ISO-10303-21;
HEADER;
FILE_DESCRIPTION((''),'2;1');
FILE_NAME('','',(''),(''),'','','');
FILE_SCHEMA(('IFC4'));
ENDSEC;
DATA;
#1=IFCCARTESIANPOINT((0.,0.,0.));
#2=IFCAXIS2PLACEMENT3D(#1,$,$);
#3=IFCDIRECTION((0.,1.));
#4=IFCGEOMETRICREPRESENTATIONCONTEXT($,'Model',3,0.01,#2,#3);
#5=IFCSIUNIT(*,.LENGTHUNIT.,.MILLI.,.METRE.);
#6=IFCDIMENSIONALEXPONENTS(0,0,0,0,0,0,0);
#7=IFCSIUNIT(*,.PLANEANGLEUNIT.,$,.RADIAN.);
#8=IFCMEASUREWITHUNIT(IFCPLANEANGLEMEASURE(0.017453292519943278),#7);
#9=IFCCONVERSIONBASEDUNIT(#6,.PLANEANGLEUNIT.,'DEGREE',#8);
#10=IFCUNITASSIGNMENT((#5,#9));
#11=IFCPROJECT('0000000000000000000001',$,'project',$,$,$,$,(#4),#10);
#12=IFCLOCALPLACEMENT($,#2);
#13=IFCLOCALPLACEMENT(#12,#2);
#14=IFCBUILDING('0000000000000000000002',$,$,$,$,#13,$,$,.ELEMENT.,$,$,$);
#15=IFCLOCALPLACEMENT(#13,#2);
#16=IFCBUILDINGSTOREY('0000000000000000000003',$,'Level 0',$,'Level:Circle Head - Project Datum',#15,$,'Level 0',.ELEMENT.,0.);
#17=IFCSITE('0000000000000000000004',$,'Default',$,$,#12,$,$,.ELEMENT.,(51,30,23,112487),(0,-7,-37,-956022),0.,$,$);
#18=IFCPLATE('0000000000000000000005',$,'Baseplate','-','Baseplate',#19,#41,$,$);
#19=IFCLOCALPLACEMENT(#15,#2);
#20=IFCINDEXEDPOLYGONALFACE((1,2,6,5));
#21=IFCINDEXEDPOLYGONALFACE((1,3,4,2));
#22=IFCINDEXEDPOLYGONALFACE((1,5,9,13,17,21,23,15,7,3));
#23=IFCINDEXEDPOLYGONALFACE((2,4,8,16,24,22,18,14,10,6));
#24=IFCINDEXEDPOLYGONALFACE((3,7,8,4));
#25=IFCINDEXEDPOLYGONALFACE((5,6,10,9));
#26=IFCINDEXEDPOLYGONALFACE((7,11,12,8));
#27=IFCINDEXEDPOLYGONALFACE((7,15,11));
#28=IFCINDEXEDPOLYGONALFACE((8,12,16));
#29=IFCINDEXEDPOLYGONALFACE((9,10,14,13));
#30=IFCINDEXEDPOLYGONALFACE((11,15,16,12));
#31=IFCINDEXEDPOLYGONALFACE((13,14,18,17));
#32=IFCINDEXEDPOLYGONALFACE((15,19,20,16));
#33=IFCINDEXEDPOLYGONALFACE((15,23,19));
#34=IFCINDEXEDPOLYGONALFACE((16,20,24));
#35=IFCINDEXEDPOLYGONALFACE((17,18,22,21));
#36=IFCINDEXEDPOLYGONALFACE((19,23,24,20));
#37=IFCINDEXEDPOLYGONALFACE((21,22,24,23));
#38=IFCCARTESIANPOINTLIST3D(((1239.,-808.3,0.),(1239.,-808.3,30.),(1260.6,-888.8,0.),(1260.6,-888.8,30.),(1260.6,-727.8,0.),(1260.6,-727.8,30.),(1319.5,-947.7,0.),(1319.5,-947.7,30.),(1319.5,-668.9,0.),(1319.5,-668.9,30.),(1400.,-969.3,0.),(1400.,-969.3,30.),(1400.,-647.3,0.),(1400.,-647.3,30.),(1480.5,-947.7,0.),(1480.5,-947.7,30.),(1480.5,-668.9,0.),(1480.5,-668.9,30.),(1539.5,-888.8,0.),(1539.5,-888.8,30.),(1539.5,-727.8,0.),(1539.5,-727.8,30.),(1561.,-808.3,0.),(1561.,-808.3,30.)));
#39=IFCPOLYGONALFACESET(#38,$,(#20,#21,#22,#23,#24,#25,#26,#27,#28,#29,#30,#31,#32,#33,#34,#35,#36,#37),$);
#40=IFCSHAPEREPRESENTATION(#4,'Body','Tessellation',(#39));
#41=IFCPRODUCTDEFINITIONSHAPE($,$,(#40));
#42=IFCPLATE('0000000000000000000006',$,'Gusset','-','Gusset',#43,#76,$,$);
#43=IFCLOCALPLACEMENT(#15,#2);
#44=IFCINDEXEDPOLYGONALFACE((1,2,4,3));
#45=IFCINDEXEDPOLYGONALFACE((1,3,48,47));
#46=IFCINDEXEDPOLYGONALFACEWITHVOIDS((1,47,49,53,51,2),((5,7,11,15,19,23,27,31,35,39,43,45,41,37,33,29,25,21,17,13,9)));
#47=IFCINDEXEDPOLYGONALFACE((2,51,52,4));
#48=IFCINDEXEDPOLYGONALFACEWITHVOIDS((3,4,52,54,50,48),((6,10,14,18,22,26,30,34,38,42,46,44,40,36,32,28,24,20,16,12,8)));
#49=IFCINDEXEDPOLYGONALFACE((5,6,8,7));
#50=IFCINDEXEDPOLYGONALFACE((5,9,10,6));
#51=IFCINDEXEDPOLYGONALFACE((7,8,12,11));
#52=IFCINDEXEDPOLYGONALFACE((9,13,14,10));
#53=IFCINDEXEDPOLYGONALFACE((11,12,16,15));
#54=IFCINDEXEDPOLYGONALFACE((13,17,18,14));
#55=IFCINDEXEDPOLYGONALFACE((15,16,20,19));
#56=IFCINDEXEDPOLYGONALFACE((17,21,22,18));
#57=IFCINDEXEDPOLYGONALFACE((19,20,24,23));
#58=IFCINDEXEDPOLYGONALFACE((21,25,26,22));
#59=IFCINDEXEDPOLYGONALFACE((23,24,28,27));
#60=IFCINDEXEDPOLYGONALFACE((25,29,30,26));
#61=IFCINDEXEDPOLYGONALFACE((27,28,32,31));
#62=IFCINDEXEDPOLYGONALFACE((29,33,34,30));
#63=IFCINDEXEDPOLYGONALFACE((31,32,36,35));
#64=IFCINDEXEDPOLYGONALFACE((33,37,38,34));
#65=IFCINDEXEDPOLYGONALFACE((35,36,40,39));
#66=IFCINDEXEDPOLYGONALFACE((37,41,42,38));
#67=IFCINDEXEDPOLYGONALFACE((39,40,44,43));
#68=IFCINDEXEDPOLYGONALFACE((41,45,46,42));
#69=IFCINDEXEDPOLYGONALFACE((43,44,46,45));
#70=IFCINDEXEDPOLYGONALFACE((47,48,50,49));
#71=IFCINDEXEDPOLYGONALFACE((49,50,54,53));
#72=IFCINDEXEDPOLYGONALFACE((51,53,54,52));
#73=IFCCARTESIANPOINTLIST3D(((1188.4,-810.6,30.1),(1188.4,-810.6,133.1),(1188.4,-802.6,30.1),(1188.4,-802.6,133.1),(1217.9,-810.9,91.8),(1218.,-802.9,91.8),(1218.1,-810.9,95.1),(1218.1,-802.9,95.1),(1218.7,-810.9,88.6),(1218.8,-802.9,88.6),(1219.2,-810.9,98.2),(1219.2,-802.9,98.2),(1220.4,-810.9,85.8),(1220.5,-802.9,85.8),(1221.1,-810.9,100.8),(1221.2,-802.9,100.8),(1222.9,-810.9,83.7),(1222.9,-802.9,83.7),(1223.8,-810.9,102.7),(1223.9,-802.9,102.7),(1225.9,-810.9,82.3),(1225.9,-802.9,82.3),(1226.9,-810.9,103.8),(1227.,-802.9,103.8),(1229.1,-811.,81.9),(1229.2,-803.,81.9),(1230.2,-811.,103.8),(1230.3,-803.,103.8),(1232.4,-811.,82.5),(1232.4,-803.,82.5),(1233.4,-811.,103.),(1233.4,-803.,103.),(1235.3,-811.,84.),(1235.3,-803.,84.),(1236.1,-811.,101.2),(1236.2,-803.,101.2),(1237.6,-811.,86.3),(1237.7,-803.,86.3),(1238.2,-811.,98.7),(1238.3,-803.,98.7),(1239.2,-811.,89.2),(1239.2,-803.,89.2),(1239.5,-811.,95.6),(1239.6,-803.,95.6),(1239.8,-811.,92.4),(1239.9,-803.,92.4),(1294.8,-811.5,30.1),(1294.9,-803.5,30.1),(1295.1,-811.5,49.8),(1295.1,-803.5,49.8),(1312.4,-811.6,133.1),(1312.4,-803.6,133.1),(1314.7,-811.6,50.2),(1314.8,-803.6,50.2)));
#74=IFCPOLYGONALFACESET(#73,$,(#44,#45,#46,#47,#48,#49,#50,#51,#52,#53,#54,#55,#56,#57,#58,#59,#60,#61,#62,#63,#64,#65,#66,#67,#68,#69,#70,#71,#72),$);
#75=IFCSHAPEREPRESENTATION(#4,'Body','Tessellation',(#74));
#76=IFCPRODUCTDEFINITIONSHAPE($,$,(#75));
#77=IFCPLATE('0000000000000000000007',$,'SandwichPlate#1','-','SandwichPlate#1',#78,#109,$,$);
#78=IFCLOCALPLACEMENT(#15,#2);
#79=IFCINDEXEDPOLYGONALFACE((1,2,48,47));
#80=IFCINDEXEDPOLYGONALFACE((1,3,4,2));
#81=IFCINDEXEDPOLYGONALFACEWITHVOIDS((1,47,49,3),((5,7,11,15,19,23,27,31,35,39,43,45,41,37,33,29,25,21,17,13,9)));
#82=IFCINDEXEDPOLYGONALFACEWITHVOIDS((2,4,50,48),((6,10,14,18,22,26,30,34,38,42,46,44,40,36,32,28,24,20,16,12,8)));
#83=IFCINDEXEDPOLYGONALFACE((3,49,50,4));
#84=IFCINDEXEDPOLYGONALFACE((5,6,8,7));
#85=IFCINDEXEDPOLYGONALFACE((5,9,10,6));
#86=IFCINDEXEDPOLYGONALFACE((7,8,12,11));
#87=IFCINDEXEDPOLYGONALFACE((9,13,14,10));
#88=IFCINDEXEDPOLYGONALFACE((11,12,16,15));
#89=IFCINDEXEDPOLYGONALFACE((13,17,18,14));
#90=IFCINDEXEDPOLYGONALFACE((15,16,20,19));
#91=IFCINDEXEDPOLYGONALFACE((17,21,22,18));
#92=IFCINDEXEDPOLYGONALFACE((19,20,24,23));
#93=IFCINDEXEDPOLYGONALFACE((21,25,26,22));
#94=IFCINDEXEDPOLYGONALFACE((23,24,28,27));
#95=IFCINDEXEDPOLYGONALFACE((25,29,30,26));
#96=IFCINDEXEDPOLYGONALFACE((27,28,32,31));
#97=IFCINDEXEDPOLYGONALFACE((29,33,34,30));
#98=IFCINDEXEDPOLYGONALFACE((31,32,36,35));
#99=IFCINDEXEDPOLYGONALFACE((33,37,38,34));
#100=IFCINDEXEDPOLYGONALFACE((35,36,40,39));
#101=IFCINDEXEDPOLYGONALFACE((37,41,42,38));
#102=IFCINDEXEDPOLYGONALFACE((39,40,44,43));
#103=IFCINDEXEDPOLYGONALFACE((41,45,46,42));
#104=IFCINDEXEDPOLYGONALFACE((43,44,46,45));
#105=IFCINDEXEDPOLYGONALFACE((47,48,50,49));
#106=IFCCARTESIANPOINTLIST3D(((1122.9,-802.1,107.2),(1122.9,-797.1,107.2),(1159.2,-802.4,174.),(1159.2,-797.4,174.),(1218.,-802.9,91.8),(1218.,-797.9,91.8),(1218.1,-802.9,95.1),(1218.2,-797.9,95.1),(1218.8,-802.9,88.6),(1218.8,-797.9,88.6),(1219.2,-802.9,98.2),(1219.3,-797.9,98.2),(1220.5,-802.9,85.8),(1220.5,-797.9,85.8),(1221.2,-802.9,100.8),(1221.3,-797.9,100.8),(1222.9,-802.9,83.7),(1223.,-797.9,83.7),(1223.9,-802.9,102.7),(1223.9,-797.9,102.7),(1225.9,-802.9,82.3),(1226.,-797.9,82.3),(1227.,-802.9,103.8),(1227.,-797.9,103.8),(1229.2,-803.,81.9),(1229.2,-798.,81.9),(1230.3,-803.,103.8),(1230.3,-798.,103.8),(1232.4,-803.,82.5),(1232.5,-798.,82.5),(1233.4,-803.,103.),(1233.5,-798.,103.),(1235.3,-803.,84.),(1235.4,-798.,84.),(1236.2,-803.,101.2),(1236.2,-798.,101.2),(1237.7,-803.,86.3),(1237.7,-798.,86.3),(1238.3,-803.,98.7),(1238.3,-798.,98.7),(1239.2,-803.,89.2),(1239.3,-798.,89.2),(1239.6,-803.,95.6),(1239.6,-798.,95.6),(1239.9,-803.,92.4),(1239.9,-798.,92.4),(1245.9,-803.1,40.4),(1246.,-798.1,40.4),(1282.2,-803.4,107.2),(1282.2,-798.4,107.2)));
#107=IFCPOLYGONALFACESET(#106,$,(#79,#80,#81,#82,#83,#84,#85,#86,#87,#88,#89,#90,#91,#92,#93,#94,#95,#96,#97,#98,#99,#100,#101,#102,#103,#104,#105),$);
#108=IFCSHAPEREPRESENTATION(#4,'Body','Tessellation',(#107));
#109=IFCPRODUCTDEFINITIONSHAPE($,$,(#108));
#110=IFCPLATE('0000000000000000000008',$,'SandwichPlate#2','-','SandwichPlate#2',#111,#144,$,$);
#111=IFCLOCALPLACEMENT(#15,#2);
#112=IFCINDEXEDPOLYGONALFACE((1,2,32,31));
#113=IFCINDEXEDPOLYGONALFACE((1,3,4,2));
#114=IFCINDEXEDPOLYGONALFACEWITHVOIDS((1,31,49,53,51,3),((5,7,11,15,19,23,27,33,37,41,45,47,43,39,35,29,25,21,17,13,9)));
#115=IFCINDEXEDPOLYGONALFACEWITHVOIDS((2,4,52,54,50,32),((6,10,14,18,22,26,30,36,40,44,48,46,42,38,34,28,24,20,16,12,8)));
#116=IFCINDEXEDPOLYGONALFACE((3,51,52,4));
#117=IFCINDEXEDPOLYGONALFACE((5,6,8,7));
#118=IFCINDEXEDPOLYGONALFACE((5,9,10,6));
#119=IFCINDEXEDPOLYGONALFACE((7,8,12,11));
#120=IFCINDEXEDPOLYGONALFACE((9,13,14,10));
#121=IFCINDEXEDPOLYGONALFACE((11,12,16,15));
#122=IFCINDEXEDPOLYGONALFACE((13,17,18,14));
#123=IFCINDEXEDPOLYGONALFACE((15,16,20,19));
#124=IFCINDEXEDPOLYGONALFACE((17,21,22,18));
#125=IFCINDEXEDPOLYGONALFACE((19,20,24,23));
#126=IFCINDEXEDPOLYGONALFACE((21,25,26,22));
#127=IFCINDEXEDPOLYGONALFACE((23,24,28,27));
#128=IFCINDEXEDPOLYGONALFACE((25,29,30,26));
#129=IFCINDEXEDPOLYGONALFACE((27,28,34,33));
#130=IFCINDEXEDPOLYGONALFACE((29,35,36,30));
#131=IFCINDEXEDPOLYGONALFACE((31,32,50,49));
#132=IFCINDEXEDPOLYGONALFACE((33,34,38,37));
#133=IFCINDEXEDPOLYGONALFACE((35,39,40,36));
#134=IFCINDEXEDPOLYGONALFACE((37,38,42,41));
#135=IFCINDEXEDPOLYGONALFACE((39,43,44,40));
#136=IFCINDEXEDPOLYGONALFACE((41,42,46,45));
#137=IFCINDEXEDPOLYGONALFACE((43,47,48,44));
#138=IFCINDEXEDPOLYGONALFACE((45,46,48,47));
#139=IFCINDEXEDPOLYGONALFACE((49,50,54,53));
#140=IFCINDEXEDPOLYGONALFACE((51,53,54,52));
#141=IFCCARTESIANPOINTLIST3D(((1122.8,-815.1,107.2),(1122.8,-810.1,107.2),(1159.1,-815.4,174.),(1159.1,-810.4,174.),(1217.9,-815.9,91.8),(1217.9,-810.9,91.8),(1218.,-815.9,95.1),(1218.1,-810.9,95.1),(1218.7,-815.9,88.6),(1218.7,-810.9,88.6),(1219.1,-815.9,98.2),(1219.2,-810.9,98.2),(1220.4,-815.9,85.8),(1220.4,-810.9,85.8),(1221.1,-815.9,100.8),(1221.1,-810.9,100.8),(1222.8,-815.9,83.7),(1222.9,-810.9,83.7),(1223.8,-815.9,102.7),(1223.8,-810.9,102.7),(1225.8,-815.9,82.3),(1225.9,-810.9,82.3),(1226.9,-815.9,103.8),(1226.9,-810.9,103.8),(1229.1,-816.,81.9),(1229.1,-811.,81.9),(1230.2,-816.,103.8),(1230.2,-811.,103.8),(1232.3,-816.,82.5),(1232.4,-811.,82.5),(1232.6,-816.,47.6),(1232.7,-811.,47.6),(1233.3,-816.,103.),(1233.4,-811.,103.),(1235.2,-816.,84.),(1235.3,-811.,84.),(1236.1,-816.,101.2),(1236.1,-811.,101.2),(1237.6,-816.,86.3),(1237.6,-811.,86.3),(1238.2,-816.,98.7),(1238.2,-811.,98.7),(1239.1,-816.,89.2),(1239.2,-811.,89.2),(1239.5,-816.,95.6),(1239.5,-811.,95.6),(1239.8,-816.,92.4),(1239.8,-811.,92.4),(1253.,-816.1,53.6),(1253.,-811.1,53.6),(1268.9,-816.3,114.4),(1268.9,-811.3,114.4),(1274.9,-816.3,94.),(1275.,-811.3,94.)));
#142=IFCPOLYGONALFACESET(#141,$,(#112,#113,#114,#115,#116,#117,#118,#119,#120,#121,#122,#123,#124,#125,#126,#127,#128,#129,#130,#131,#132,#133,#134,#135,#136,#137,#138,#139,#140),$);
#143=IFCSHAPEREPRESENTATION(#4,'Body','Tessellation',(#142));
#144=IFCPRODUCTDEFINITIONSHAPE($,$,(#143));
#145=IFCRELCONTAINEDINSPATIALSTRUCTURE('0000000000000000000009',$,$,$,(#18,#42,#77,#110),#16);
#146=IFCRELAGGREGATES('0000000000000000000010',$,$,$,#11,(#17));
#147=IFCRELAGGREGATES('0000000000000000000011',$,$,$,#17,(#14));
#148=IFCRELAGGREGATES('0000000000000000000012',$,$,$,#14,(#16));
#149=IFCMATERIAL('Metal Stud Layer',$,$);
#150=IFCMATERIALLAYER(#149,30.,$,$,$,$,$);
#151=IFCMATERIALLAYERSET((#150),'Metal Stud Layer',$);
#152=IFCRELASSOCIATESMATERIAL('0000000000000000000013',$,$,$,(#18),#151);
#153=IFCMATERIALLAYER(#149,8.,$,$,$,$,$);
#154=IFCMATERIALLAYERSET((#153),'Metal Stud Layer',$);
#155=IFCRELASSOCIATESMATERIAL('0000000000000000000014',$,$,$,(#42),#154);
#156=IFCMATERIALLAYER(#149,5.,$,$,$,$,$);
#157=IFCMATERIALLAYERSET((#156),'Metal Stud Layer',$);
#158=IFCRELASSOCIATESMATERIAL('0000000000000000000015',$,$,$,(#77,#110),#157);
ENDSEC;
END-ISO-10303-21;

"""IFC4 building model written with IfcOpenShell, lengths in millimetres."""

from ifc_helpers import new_model, entity, si_unit, converted_unit, point, direction, frame, frame_2d, origin, origin_with_axes, origin_2d_with_axis, place, context, project, spatial, polyline, circle_curve, line_curve, trimmed, segment, composite_curve, circle, outline, extrude, material, layer, layer_set, element, save


model = new_model("IFC4")

# Units and contexts
model_context = context("Model", 3, precision=0.01, world=origin(), true_north=direction((0.0, 1.0)))
ifc_project = project(units=[si_unit("LENGTHUNIT", "METRE", prefix="MILLI"), converted_unit("PLANEANGLEUNIT", "DEGREE", entity("IfcPlaneAngleMeasure", 0.017453292519943278), si_unit("PLANEANGLEUNIT", "RADIAN"), dimensions=[0, 0, 0, 0, 0, 0, 0])], contexts=[model_context])

# Site, building, storey
site_placement = place(None, origin())
site = spatial("IfcSite", under=ifc_project, at=site_placement, Name="Default", CompositionType="ELEMENT", RefLatitude=(51, 30, 23, 112487), RefLongitude=(0, -7, -37, -956022), RefElevation=0.0)
building_placement = place(site_placement, origin())
building = spatial("IfcBuilding", under=site, at=building_placement, CompositionType="ELEMENT")
storey_placement = place(building_placement, origin())
storey = spatial("IfcBuildingStorey", under=building, at=storey_placement, Name="Level 0", ObjectType="Level:Circle Head - Project Datum", LongName="Level 0", CompositionType="ELEMENT", Elevation=0.0)

# Plates, openings
ifc_material_1 = material(Name="Metal Stud Layer")
ifc_layer_1 = layer(ifc_material_1, 30.0)
ifc_layer_set_1 = layer_set([ifc_layer_1], Name="Metal Stud Layer")
plate_1_placement = place(storey_placement, frame((1480.5, -668.9, 30.0), z_axis=(0.0, 0.0, -1.0), x_axis=(0.866025, -0.5, 0.0)))
plate_1 = element("IfcPlate", 1, at=plate_1_placement, inside=storey, material=ifc_layer_set_1, Name="Baseplate", Description="-", ObjectType="Baseplate", context=model_context, shape_type="SweptSolid", body=[
    extrude(outline(polyline([(161.0, 0.0), (161.0, 322.0), (-161.0, 322.0), (-161.0, 0.0), (161.0, 0.0)])), origin_with_axes(), (0.0, 0.0, 1.0), 30.0),
])
opening_1_placement = place(plate_1_placement, frame((0.0, 0.0, 0.0), z_axis=(0.0, 0.0, 1.0), x_axis=(1.0, 0.0, 0.0)))
element("IfcOpeningElement", 2, at=opening_1_placement, cuts=plate_1, ObjectType="Opening", context=model_context, shape_type="SweptSolid", body=[
    extrude(outline(composite_curve([segment(trimmed(line_curve((161.0, 0.0), (0.0, 1.0), 161.0), [point((161.0, 0.0))], [point((161.0, 161.0))], True, "CARTESIAN"), True, "CONTINUOUS"), segment(trimmed(circle_curve(frame_2d((0.0, 161.0), x_axis=(-1.0, 0.0)), 161.0), [point((161.0, 161.0))], [point((0.0, 0.0))], False, "CARTESIAN"), True, "CONTINUOUS"), segment(trimmed(line_curve((0.0, 0.0), (1.0, 0.0), 161.0), [point((0.0, 0.0))], [point((161.0, 0.0))], True, "CARTESIAN"), True, "CONTINUOUS")], self_intersect="UNKNOWN")), origin(), (0.0, 0.0, 1.0), 30.0),
])
opening_2_placement = place(plate_1_placement, frame((0.0, 0.0, 0.0), z_axis=(0.0, 0.0, 1.0), x_axis=(1.0, 0.0, 0.0)))
element("IfcOpeningElement", 3, at=opening_2_placement, cuts=plate_1, ObjectType="Opening", context=model_context, shape_type="SweptSolid", body=[
    extrude(outline(composite_curve([segment(trimmed(line_curve((161.0, 322.0), (-1.0, 0.0), 161.0), [point((161.0, 322.0))], [point((0.0, 322.0))], True, "CARTESIAN"), True, "CONTINUOUS"), segment(trimmed(circle_curve(frame_2d((0.0, 161.0), x_axis=(-1.0, 0.0)), 161.0), [point((0.0, 322.0))], [point((161.0, 161.0))], False, "CARTESIAN"), True, "CONTINUOUS"), segment(trimmed(line_curve((161.0, 161.0), (0.0, 1.0), 161.0), [point((161.0, 161.0))], [point((161.0, 322.0))], True, "CARTESIAN"), True, "CONTINUOUS")], self_intersect="UNKNOWN")), origin(), (0.0, 0.0, 1.0), 30.0),
])
opening_3_placement = place(plate_1_placement, frame((0.0, 0.0, 0.0), z_axis=(0.0, 0.0, 1.0), x_axis=(1.0, 0.0, 0.0)))
element("IfcOpeningElement", 4, at=opening_3_placement, cuts=plate_1, ObjectType="Opening", context=model_context, shape_type="SweptSolid", body=[
    extrude(outline(composite_curve([segment(trimmed(line_curve((-161.0, 322.0), (0.0, -1.0), 161.0), [point((-161.0, 322.0))], [point((-161.0, 161.0))], True, "CARTESIAN"), True, "CONTINUOUS"), segment(trimmed(circle_curve(frame_2d((0.0, 161.0), x_axis=(-1.0, 0.0)), 161.0), [point((-161.0, 161.0))], [point((0.0, 322.0))], False, "CARTESIAN"), True, "CONTINUOUS"), segment(trimmed(line_curve((0.0, 322.0), (-1.0, 0.0), 161.0), [point((0.0, 322.0))], [point((-161.0, 322.0))], True, "CARTESIAN"), True, "CONTINUOUS")], self_intersect="UNKNOWN")), origin(), (0.0, 0.0, 1.0), 30.0),
])
opening_4_placement = place(plate_1_placement, frame((0.0, 0.0, 0.0), z_axis=(0.0, 0.0, 1.0), x_axis=(1.0, 0.0, 0.0)))
element("IfcOpeningElement", 5, at=opening_4_placement, cuts=plate_1, ObjectType="Opening", context=model_context, shape_type="SweptSolid", body=[
    extrude(outline(composite_curve([segment(trimmed(line_curve((-161.0, 0.0), (1.0, 0.0), 161.0), [point((-161.0, 0.0))], [point((0.0, 0.0))], True, "CARTESIAN"), True, "CONTINUOUS"), segment(trimmed(circle_curve(frame_2d((0.0, 161.0), x_axis=(-1.0, 0.0)), 161.0), [point((0.0, 0.0))], [point((-161.0, 161.0))], False, "CARTESIAN"), True, "CONTINUOUS"), segment(trimmed(line_curve((-161.0, 161.0), (0.0, -1.0), 161.0), [point((-161.0, 161.0))], [point((-161.0, 0.0))], True, "CARTESIAN"), True, "CONTINUOUS")], self_intersect="UNKNOWN")), origin(), (0.0, 0.0, 1.0), 30.0),
])
ifc_layer_2 = layer(ifc_material_1, 8.0)
ifc_layer_set_2 = layer_set([ifc_layer_2], Name="Metal Stud Layer")
plate_2_placement = place(storey_placement, frame((1309.2, -803.6, 143.6), z_axis=(-0.007837, -0.999969, 0.0), x_axis=(-0.999419, 0.007833, -0.033166)))
plate_2 = element("IfcPlate", 6, at=plate_2_placement, inside=storey, material=ifc_layer_set_2, Name="Gusset", Description="-", ObjectType="Gusset", context=model_context, shape_type="SweptSolid", body=[
    extrude(outline(polyline([(-2.5, 93.5), (-2.9, 10.5), (121.1, 6.4), (124.5, 109.4), (18.1, 112.9), (17.2, 93.2), (-2.5, 93.5)])), origin_with_axes(), (0.0, 0.0, 1.0), 8.0),
])
opening_5_placement = place(plate_2_placement, origin_with_axes())
element("IfcOpeningElement", 7, at=opening_5_placement, cuts=plate_2, ObjectType="Opening", context=model_context, shape_type="SweptSolid", body=[
    extrude(outline(composite_curve([segment(trimmed(line_curve((17.2, 93.2), (-0.999857, 0.016904), 19.685532), [point((17.2, 93.2))], [point((-2.5, 93.5))], True, "CARTESIAN"), True, "CONTINUOUS"), segment(trimmed(circle_curve(frame_2d((-2.2, 113.8), x_axis=(1.0, 0.0)), 20.3), [point((-2.5, 93.5))], [point((18.1, 112.9))], True, "CARTESIAN"), True, "CONTINUOUS"), segment(trimmed(line_curve((18.1, 112.9), (-0.046684, -0.99891), 19.685532), [point((18.1, 112.9))], [point((17.2, 93.2))], True, "CARTESIAN"), True, "CONTINUOUS")], self_intersect="UNKNOWN")), origin(), (0.0, 0.0, 1.0), 8.0),
])
opening_6_placement = place(plate_2_placement, frame((81.9, 48.0, 8.5), z_axis=(0.0, 0.0, -1.0), x_axis=(0.862503, -0.506052, 0.0)))
element("IfcOpeningElement", 8, at=opening_6_placement, cuts=plate_2, ObjectType="Opening", context=model_context, shape_type="SweptSolid", body=[
    extrude(circle(Radius=11.0, at=origin_2d_with_axis()), origin(), (0.0, 0.0, 1.0), 9.0),
])

# Plates, openings
ifc_layer_3 = layer(ifc_material_1, 5.0)
ifc_layer_set_3 = layer_set([ifc_layer_3], Name="Metal Stud Layer")
plate_3_placement = place(storey_placement, frame((1282.2, -803.4, 107.2), z_axis=(0.007837, 0.999969, 0.0), x_axis=(-0.477154, 0.00374, -0.878812)))
plate_3 = element("IfcPlate", 9, at=plate_3_placement, inside=storey, material=ifc_layer_set_3, Name="SandwichPlate#1", Description="-", ObjectType="SandwichPlate#1", context=model_context, shape_type="SweptSolid", body=[
    extrude(outline(polyline([(0.0, 0.0), (76.0, 0.0), (76.0, 140.0), (0.0, 140.0), (0.0, 0.0)])), origin_with_axes(), (0.0, 0.0, 1.0), 5.0),
])
opening_7_placement = place(plate_3_placement, frame((38.0, 40.0, -0.5), z_axis=(0.0, 0.0, 1.0), x_axis=(0.0, 1.0, 0.0)))
element("IfcOpeningElement", 10, at=opening_7_placement, cuts=plate_3, ObjectType="Opening", context=model_context, shape_type="SweptSolid", body=[
    extrude(circle(Radius=11.0, at=origin_2d_with_axis()), origin(), (0.0, 0.0, 1.0), 6.0),
])
plate_4_placement = place(storey_placement, frame((1282.1, -816.4, 107.2), z_axis=(0.007837, 0.999969, 0.0), x_axis=(-0.477154, 0.00374, -0.878812)))
plate_4 = element("IfcPlate", 11, at=plate_4_placement, inside=storey, material=ifc_layer_set_3, Name="SandwichPlate#2", Description="-", ObjectType="SandwichPlate#2", context=model_context, shape_type="SweptSolid", body=[
    extrude(outline(polyline([(15.0, 0.0), (61.0, 0.0), (76.0, 15.0), (76.0, 140.0), (0.0, 140.0), (0.0, 15.0), (15.0, 0.0)])), origin_with_axes(), (0.0, 0.0, 1.0), 5.0),
])
opening_8_placement = place(plate_4_placement, frame((38.0, 40.0, -0.5), z_axis=(0.0, 0.0, 1.0), x_axis=(0.0, 1.0, 0.0)))
element("IfcOpeningElement", 12, at=opening_8_placement, cuts=plate_4, ObjectType="Opening", context=model_context, shape_type="SweptSolid", body=[
    extrude(circle(Radius=11.0, at=origin_2d_with_axis()), origin(), (0.0, 0.0, 1.0), 6.0),
])

save(model, "model.ifc")
